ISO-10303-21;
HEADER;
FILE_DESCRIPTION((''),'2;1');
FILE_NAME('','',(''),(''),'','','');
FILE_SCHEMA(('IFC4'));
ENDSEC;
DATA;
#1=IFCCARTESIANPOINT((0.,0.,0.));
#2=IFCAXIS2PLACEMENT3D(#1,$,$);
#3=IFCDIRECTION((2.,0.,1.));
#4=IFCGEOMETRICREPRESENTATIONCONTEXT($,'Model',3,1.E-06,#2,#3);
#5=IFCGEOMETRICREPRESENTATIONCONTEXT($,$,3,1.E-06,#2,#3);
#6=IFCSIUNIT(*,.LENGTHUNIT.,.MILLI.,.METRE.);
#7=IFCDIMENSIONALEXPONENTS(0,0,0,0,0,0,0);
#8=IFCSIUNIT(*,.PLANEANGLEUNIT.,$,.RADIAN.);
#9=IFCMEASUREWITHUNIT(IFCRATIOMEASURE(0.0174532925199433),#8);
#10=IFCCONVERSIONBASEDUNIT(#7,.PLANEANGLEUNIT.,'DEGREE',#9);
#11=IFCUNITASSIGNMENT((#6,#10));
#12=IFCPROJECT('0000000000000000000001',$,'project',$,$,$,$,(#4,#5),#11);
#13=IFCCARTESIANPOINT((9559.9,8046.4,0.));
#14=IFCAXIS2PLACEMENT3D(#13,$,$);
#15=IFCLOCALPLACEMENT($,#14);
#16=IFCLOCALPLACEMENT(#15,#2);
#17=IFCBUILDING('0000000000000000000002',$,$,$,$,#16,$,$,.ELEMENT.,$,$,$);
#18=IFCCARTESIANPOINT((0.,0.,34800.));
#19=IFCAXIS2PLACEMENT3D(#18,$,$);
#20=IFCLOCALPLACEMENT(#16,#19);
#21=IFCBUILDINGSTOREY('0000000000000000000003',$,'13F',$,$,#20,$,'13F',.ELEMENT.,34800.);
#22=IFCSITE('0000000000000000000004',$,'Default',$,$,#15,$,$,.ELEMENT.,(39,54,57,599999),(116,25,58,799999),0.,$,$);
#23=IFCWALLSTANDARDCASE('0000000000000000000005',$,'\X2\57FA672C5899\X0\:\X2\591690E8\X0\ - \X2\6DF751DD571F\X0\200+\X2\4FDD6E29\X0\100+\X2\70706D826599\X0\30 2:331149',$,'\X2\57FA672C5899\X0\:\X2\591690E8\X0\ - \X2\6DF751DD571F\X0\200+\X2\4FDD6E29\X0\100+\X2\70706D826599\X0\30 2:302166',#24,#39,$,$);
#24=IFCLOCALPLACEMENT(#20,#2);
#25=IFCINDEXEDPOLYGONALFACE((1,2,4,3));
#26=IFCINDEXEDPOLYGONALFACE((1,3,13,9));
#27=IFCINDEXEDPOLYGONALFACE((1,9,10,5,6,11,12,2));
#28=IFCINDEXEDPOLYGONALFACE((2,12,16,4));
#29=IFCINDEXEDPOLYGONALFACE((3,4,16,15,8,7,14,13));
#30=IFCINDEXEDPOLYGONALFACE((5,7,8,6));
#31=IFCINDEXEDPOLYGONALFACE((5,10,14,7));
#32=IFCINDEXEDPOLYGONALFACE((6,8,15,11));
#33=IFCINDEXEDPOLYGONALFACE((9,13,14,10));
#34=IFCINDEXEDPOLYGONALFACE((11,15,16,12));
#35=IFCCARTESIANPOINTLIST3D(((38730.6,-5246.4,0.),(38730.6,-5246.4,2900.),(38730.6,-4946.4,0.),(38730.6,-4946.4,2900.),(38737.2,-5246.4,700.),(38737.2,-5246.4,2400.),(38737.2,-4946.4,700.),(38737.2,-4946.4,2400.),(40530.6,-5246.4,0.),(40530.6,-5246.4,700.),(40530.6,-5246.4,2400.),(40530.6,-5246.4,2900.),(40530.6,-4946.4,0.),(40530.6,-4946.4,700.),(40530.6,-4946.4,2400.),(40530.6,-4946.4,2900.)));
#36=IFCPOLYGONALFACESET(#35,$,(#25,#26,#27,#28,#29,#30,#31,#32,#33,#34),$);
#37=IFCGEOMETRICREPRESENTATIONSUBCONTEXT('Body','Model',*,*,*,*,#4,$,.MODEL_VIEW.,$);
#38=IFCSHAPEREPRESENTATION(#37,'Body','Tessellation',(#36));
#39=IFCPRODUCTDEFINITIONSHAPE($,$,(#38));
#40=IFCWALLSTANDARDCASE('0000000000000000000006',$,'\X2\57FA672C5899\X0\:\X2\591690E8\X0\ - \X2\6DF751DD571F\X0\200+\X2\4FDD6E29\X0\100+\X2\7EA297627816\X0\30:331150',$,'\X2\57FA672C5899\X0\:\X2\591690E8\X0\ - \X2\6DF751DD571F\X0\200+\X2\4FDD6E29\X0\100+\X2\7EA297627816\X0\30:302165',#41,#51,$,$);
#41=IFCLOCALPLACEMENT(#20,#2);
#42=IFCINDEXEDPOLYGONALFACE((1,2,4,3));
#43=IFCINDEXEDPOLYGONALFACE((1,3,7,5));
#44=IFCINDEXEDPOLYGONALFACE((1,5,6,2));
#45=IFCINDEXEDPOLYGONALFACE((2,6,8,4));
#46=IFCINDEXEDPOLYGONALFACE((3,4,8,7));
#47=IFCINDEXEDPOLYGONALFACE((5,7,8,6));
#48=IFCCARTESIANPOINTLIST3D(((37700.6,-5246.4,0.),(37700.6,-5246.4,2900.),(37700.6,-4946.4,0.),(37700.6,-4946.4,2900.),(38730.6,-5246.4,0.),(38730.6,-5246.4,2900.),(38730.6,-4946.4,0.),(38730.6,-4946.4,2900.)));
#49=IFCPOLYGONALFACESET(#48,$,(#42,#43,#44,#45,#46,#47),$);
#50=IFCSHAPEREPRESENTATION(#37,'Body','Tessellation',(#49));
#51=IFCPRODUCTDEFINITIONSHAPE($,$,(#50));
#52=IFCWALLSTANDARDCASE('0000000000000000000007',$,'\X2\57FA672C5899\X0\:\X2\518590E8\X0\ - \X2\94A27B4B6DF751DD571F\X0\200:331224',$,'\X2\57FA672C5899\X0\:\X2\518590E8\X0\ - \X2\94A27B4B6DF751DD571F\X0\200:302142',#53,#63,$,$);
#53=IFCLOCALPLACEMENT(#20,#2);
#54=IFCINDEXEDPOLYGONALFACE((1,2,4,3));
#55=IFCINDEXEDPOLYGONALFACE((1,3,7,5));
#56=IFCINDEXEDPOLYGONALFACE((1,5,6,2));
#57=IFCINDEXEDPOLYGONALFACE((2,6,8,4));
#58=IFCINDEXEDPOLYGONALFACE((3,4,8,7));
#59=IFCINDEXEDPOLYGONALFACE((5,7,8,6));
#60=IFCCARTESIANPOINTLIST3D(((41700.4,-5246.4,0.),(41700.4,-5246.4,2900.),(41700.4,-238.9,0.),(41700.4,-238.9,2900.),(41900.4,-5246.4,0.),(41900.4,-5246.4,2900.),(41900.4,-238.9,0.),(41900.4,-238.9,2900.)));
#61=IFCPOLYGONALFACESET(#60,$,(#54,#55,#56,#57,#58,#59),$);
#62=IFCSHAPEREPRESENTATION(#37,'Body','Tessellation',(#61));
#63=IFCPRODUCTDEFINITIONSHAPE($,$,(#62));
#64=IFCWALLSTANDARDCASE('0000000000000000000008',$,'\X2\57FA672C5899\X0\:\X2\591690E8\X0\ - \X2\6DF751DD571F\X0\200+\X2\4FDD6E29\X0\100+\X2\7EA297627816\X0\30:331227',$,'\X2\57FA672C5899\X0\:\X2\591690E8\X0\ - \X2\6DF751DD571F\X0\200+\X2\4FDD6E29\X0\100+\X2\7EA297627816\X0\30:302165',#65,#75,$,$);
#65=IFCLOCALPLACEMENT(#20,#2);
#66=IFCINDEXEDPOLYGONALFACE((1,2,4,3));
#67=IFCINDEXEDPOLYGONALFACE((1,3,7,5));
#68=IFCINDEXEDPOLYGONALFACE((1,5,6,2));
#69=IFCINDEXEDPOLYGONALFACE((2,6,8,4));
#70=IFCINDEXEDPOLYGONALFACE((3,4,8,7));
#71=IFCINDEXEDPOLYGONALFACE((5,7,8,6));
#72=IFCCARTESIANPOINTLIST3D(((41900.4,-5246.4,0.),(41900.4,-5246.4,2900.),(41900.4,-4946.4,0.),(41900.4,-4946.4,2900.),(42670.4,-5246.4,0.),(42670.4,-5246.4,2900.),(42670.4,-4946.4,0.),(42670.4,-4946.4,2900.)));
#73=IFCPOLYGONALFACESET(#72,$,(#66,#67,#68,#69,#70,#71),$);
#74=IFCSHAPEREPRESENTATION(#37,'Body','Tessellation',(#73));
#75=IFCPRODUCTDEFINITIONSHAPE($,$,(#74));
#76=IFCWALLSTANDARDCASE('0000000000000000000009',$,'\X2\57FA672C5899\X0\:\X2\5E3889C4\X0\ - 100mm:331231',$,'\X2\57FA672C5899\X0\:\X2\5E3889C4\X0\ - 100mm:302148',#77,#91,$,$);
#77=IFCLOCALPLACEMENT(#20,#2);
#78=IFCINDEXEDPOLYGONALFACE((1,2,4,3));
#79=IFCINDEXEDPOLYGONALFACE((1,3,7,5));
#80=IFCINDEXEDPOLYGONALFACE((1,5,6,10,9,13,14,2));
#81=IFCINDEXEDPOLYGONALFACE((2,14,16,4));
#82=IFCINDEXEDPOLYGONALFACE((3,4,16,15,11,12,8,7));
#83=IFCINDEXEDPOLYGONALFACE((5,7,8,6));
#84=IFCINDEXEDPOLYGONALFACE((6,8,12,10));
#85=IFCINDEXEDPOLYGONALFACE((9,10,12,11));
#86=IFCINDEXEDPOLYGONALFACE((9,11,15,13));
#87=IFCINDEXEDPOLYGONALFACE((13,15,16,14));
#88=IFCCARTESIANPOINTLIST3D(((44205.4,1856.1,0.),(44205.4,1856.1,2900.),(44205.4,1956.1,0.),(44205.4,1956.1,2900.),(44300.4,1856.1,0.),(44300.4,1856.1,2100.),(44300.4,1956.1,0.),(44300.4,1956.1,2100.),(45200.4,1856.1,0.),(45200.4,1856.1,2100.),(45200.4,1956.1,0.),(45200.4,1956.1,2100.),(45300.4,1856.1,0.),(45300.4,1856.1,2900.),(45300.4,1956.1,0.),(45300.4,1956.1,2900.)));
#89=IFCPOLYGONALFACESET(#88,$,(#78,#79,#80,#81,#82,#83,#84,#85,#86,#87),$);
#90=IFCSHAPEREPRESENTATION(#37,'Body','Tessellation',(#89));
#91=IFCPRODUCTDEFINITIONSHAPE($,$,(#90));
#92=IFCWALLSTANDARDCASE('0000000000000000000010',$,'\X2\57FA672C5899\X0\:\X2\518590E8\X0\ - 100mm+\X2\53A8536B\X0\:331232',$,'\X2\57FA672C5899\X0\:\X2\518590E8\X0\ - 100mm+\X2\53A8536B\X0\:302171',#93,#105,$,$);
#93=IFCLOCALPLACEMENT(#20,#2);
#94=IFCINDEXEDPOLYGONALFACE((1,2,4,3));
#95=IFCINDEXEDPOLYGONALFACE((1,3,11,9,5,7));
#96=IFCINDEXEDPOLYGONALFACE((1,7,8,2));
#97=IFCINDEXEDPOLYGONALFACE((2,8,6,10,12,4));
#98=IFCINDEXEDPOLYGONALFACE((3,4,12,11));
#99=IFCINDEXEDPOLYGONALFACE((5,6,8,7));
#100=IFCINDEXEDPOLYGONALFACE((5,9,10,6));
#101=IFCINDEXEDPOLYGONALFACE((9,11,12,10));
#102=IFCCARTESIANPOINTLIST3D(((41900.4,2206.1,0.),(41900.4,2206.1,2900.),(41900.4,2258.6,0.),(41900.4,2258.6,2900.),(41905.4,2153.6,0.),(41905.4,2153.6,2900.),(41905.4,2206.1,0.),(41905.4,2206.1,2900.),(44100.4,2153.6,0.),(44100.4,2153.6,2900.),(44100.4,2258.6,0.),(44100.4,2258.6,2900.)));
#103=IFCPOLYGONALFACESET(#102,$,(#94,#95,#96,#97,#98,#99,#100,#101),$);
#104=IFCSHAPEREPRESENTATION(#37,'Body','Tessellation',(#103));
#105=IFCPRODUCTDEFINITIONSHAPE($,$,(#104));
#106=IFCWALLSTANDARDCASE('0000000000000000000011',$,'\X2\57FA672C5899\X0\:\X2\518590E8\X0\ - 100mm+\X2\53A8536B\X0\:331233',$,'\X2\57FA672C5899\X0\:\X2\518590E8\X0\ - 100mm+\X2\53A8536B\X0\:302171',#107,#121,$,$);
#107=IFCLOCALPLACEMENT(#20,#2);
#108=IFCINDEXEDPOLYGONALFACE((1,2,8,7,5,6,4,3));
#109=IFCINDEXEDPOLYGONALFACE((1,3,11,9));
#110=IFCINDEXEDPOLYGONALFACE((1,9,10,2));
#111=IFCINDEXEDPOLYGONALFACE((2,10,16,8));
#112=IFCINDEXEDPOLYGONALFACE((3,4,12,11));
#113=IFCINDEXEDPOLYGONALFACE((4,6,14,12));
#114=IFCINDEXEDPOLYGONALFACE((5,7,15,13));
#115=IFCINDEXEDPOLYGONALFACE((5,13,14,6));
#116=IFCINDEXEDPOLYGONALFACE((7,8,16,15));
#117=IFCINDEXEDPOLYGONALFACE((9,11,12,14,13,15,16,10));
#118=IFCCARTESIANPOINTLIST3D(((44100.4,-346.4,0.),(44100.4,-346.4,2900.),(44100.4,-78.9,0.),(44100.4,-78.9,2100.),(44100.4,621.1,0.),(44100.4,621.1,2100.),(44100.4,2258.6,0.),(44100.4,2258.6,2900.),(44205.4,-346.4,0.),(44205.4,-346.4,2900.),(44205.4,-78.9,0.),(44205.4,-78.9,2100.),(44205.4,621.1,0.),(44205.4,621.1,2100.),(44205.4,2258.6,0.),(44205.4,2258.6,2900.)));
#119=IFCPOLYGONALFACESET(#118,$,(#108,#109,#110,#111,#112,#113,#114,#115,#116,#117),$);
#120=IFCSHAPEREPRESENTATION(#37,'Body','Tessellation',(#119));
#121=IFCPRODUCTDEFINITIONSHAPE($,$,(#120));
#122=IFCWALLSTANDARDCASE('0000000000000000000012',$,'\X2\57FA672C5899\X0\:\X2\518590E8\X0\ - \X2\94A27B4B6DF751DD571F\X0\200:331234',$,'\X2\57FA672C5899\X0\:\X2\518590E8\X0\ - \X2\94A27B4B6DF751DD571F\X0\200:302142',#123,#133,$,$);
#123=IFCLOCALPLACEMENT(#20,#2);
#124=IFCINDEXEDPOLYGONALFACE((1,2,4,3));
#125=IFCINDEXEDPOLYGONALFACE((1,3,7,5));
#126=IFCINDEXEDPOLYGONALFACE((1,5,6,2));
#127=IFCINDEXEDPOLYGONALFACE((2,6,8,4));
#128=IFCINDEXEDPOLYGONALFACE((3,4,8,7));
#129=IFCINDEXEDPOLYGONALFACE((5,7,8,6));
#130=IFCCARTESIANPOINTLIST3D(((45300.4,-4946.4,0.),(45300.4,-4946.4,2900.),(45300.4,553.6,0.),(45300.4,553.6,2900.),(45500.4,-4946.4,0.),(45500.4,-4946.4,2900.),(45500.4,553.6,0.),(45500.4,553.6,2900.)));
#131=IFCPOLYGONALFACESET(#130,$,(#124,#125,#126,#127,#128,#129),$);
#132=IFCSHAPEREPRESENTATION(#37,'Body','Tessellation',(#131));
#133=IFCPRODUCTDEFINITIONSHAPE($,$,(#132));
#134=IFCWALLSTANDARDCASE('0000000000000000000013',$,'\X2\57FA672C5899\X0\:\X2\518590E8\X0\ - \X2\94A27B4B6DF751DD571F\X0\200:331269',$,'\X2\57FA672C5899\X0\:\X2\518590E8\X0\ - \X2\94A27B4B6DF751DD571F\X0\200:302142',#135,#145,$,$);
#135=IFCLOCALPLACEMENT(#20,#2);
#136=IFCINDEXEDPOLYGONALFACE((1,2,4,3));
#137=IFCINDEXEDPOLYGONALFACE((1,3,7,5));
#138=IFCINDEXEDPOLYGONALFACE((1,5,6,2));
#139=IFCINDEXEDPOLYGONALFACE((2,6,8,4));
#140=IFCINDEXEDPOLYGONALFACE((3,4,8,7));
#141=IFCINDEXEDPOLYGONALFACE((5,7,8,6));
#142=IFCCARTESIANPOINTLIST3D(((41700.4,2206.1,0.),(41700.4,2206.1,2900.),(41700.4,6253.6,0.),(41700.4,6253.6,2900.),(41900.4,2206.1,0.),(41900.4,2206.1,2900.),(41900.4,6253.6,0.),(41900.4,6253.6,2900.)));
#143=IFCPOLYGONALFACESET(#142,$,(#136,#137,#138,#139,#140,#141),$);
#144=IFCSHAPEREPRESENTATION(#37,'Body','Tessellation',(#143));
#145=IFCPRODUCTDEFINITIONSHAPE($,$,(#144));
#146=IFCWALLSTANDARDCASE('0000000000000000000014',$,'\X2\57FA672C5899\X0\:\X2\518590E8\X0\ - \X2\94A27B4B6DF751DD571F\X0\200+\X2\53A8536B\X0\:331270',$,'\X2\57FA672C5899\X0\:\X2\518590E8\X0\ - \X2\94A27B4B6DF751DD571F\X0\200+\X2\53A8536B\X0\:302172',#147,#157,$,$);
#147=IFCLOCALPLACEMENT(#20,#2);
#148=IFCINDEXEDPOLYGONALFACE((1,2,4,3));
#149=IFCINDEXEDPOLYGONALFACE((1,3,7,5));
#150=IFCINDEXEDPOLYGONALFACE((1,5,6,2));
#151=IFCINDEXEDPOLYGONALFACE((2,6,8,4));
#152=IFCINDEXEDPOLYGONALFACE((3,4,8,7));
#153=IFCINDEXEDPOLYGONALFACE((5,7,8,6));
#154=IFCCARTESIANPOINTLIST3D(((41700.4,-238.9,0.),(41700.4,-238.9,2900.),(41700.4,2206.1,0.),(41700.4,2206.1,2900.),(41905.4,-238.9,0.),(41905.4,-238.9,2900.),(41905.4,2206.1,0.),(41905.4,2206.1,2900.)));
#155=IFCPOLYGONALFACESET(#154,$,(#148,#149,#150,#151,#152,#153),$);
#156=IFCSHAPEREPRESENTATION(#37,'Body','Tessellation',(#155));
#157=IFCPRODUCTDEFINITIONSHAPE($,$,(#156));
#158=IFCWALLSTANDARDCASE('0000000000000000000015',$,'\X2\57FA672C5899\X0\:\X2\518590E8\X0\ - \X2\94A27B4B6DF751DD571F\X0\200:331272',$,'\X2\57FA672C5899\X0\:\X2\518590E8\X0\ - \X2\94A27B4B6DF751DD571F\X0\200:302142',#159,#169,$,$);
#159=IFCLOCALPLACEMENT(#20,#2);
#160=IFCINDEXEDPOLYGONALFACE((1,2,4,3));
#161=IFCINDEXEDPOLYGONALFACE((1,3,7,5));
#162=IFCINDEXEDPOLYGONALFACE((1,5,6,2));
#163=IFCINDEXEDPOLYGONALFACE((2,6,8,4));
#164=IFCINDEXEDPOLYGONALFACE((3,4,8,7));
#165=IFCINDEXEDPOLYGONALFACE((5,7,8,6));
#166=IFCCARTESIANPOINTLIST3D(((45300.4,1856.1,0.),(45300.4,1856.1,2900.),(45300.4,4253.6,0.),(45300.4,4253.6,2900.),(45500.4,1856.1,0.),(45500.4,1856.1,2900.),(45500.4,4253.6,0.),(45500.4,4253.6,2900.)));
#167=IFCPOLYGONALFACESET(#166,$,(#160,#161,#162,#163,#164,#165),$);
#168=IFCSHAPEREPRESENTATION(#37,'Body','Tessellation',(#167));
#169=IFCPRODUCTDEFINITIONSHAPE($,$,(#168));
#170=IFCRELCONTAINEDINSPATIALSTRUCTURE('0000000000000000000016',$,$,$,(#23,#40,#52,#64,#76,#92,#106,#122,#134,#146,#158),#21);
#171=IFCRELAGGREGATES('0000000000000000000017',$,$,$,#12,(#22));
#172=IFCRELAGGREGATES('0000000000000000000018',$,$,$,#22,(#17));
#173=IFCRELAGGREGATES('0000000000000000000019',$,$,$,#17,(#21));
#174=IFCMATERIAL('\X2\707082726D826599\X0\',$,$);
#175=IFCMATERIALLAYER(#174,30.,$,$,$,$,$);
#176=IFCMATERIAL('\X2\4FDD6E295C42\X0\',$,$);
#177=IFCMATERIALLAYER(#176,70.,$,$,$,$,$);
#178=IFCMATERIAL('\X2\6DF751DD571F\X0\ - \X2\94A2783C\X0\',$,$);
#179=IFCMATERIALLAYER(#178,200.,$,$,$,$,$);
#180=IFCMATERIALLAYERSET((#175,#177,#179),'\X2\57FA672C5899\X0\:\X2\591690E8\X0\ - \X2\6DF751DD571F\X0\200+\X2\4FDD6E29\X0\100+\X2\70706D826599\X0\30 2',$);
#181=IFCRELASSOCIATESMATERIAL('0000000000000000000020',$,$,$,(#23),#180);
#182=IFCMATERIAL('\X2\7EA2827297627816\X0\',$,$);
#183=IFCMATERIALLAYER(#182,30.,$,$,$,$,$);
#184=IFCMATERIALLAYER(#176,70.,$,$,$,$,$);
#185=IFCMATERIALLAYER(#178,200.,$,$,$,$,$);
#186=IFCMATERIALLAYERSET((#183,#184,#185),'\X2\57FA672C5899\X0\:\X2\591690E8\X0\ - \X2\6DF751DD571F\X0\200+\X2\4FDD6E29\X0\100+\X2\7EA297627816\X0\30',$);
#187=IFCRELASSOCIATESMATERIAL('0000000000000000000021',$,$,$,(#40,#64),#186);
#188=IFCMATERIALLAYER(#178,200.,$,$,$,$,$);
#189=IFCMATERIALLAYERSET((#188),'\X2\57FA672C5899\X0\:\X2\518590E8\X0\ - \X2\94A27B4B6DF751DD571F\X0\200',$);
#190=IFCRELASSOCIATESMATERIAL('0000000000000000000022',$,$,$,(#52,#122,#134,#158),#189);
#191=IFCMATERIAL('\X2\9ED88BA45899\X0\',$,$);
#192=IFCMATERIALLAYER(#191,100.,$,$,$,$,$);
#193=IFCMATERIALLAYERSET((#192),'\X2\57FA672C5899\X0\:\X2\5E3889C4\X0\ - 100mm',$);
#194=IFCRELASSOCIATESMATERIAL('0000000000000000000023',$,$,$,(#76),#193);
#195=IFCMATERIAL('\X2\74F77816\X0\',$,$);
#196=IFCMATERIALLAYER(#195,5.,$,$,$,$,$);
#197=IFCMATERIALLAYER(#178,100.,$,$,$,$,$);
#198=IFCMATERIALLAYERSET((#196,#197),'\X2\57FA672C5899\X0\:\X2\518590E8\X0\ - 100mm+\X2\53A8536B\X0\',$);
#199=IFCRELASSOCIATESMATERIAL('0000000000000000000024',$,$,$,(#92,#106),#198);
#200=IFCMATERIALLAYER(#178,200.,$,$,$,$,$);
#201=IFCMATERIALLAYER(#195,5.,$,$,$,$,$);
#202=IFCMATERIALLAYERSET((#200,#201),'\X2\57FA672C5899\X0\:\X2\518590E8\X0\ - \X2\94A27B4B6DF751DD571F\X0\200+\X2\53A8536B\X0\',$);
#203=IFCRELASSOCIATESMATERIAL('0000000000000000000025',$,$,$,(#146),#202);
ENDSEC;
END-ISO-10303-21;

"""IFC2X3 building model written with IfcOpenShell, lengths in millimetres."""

from ifc_helpers import new_model, entity, si_unit, converted_unit, direction, frame, frame_2d, origin, place, context, subcontext, project, spatial, polyline, rectangle, outline, extrude, material, layer, layer_set, layer_usage, element, save


model = new_model("IFC2X3")

# Units and contexts
model_context = context("Model", 3, precision=1e-06, world=origin(), true_north=direction((2.0, 0.0, 1.0)))
context_of_model = context(None, 3, precision=1e-06, world=origin(), true_north=direction((2.0, 0.0, 1.0)))
body_context = subcontext(model_context, "Body", "Model", "MODEL_VIEW")
ifc_project = project(units=[si_unit("LENGTHUNIT", "METRE", prefix="MILLI"), converted_unit("PLANEANGLEUNIT", "DEGREE", entity("IfcRatioMeasure", 0.0174532925199433), si_unit("PLANEANGLEUNIT", "RADIAN"), dimensions=[0, 0, 0, 0, 0, 0, 0])], contexts=[model_context, context_of_model])

# Site, building, storey
site_placement = place(None, frame((9559.9, 8046.4, 0.0)))
site = spatial("IfcSite", under=ifc_project, at=site_placement, Name="Default", CompositionType="ELEMENT", RefLatitude=(39, 54, 57, 599999), RefLongitude=(116, 25, 58, 799999), RefElevation=0.0)
building_placement = place(site_placement, origin())
building = spatial("IfcBuilding", under=site, at=building_placement, CompositionType="ELEMENT")
storey_placement = place(building_placement, frame((0.0, 0.0, 34800.0)))
storey = spatial("IfcBuildingStorey", under=building, at=storey_placement, Name="13F", LongName="13F", CompositionType="ELEMENT", Elevation=34800.0)

# Shared definitions
ifc_material_1 = material(Name="混凝土 - 钢砼")
ifc_layer_1 = layer(ifc_material_1, 200.0)
ifc_layer_set_1 = layer_set([ifc_layer_1], Name="基本墙:内部 - 钢筋混凝土200")
ifc_material_2 = material(Name="红色面砖")
ifc_layer_2 = layer(ifc_material_2, 30.0)
ifc_material_3 = material(Name="保温层")
ifc_layer_3 = layer(ifc_material_3, 70.0)
ifc_layer_4 = layer(ifc_material_1, 200.0)
ifc_layer_set_2 = layer_set([ifc_layer_2, ifc_layer_3, ifc_layer_4], Name="基本墙:外部 - 混凝土200+保温100+红面砖30")

# Shared definitions
ifc_material_4 = material(Name="默认墙")
ifc_layer_5 = layer(ifc_material_4, 100.0)
ifc_layer_set_3 = layer_set([ifc_layer_5], Name="基本墙:常规 - 100mm")

# Shared definitions
ifc_material_5 = material(Name="瓷砖")
ifc_layer_6 = layer(ifc_material_5, 5.0)
ifc_layer_7 = layer(ifc_material_1, 100.0)
ifc_layer_set_4 = layer_set([ifc_layer_6, ifc_layer_7], Name="基本墙:内部 - 100mm+厨卫")

# Shared definitions
ifc_layer_8 = layer(ifc_material_1, 200.0)
ifc_layer_9 = layer(ifc_material_5, 5.0)
ifc_layer_set_5 = layer_set([ifc_layer_8, ifc_layer_9], Name="基本墙:内部 - 钢筋混凝土200+厨卫")

# Wall, opening
ifc_material_6 = material(Name="灰色涂料")
ifc_layer_10 = layer(ifc_material_6, 30.0)
ifc_layer_11 = layer(ifc_material_3, 70.0)
ifc_layer_12 = layer(ifc_material_1, 200.0)
ifc_layer_set_6 = layer_set([ifc_layer_10, ifc_layer_11, ifc_layer_12], Name="基本墙:外部 - 混凝土200+保温100+灰涂料30 2")
ifc_layer_usage_1 = layer_usage(ifc_layer_set_6, "AXIS2", "NEGATIVE", 150.0)
wall_1_placement = place(storey_placement, frame((40530.6, -5096.4, 0.0), z_axis=(0.0, 0.0, 1.0), x_axis=(-1.0, 0.0, 0.0)))
wall_1 = element("IfcWallStandardCase", 1, at=wall_1_placement, inside=storey, material=ifc_layer_usage_1, Name="基本墙:外部 - 混凝土200+保温100+灰涂料30 2:331149", ObjectType="基本墙:外部 - 混凝土200+保温100+灰涂料30 2:302166", context=body_context, shape_type="SweptSolid", body=[
    extrude(rectangle(XDim=1800.0, YDim=300.0, at=frame_2d((900.0, 0.0), x_axis=(-1.0, 0.0))), origin(), (0.0, 0.0, 1.0), 2900.0),
])
opening_1_placement = place(wall_1_placement, frame((-6.6, -150.0, 700.0)))
element("IfcOpeningElement", 2, at=opening_1_placement, cuts=wall_1, ObjectType="Opening", context=body_context, shape_type="SweptSolid", body=[
    extrude(rectangle(XDim=1700.0, YDim=1800.0, at=frame_2d((850.0, 900.0), x_axis=(1.0, 0.0))), frame((0.0, 0.0, 0.0), z_axis=(0.0, 1.0, 0.0), x_axis=(0.0, 0.0, 1.0)), (0.0, 0.0, 1.0), 300.0),
])

# Walls
ifc_layer_usage_2 = layer_usage(ifc_layer_set_2, "AXIS2", "NEGATIVE", 150.0)
wall_2_placement = place(storey_placement, frame((38730.6, -5096.4, 0.0), z_axis=(0.0, 0.0, 1.0), x_axis=(-1.0, 0.0, 0.0)))
element("IfcWallStandardCase", 3, at=wall_2_placement, inside=storey, material=ifc_layer_usage_2, Name="基本墙:外部 - 混凝土200+保温100+红面砖30:331150", ObjectType="基本墙:外部 - 混凝土200+保温100+红面砖30:302165", context=body_context, shape_type="SweptSolid", body=[
    extrude(rectangle(XDim=1030.0, YDim=300.0, at=frame_2d((515.0, 0.0), x_axis=(-1.0, 0.0))), origin(), (0.0, 0.0, 1.0), 2900.0),
])
ifc_layer_usage_3 = layer_usage(ifc_layer_set_1, "AXIS2", "NEGATIVE", 100.0)
wall_3_placement = place(storey_placement, frame((41800.4, -5246.4, 0.0), z_axis=(0.0, 0.0, 1.0), x_axis=(0.0, 1.0, 0.0)))
element("IfcWallStandardCase", 4, at=wall_3_placement, inside=storey, material=ifc_layer_usage_3, Name="基本墙:内部 - 钢筋混凝土200:331224", ObjectType="基本墙:内部 - 钢筋混凝土200:302142", context=body_context, shape_type="SweptSolid", body=[
    extrude(rectangle(XDim=5007.5, YDim=200.0, at=frame_2d((2503.8, 0.0), x_axis=(-1.0, 0.0))), origin(), (0.0, 0.0, 1.0), 2900.0),
])
ifc_layer_usage_4 = layer_usage(ifc_layer_set_2, "AXIS2", "POSITIVE", -150.0)
wall_4_placement = place(storey_placement, frame((41900.4, -5096.4, 0.0)))
element("IfcWallStandardCase", 5, at=wall_4_placement, inside=storey, material=ifc_layer_usage_4, Name="基本墙:外部 - 混凝土200+保温100+红面砖30:331227", ObjectType="基本墙:外部 - 混凝土200+保温100+红面砖30:302165", context=body_context, shape_type="SweptSolid", body=[
    extrude(rectangle(XDim=770.0, YDim=300.0, at=frame_2d((385.0, 0.0), x_axis=(-1.0, 0.0))), origin(), (0.0, 0.0, 1.0), 2900.0),
])

# Wall, opening
ifc_layer_usage_5 = layer_usage(ifc_layer_set_3, "AXIS2", "NEGATIVE", 50.0)
wall_5_placement = place(storey_placement, frame((44205.4, 1906.1, 0.0)))
wall_5 = element("IfcWallStandardCase", 6, at=wall_5_placement, inside=storey, material=ifc_layer_usage_5, Name="基本墙:常规 - 100mm:331231", ObjectType="基本墙:常规 - 100mm:302148", context=body_context, shape_type="SweptSolid", body=[
    extrude(rectangle(XDim=1095.0, YDim=100.0, at=frame_2d((547.5, 0.0), x_axis=(-1.0, 0.0))), origin(), (0.0, 0.0, 1.0), 2900.0),
])
opening_2_placement = place(wall_5_placement, frame((95.0, -50.0, 0.0)))
element("IfcOpeningElement", 7, at=opening_2_placement, cuts=wall_5, ObjectType="Opening", context=body_context, shape_type="SweptSolid", body=[
    extrude(rectangle(XDim=2100.0, YDim=900.0, at=frame_2d((1050.0, 450.0), x_axis=(1.0, 0.0))), frame((0.0, 0.0, 0.0), z_axis=(0.0, 1.0, 0.0), x_axis=(0.0, 0.0, 1.0)), (0.0, 0.0, 1.0), 100.0),
])

# Wall
ifc_layer_usage_6 = layer_usage(ifc_layer_set_4, "AXIS2", "POSITIVE", -52.5)
wall_6_placement = place(storey_placement, frame((41900.4, 2206.1, 0.0)))
element("IfcWallStandardCase", 8, at=wall_6_placement, inside=storey, material=ifc_layer_usage_6, Name="基本墙:内部 - 100mm+厨卫:331232", ObjectType="基本墙:内部 - 100mm+厨卫:302171", context=body_context, shape_type="SweptSolid", body=[
    extrude(outline(polyline([(2200.0, -52.5), (2200.0, 52.5), (0.0, 52.5), (0.0, 0.0), (5.0, 0.0), (5.0, -52.5), (2200.0, -52.5)])), origin(), (0.0, 0.0, 1.0), 2900.0),
])

# Wall, opening
ifc_layer_usage_7 = layer_usage(ifc_layer_set_4, "AXIS2", "POSITIVE", -52.5)
wall_7_placement = place(storey_placement, frame((44152.9, 2258.6, 0.0), z_axis=(0.0, 0.0, 1.0), x_axis=(0.0, -1.0, 0.0)))
wall_7 = element("IfcWallStandardCase", 9, at=wall_7_placement, inside=storey, material=ifc_layer_usage_7, Name="基本墙:内部 - 100mm+厨卫:331233", ObjectType="基本墙:内部 - 100mm+厨卫:302171", context=body_context, shape_type="SweptSolid", body=[
    extrude(rectangle(XDim=2605.0, YDim=105.0, at=frame_2d((1302.5, 0.0), x_axis=(-1.0, 0.0))), origin(), (0.0, 0.0, 1.0), 2900.0),
])
opening_3_placement = place(wall_7_placement, frame((2337.5, 52.5, 0.0)))
element("IfcOpeningElement", 10, at=opening_3_placement, cuts=wall_7, ObjectType="Opening", context=body_context, shape_type="SweptSolid", body=[
    extrude(rectangle(XDim=2100.0, YDim=700.0, at=frame_2d((1050.0, 350.0), x_axis=(1.0, 0.0))), frame((0.0, 0.0, 0.0), z_axis=(0.0, -1.0, 0.0), x_axis=(0.0, 0.0, 1.0)), (0.0, 0.0, 1.0), 105.0),
])

# Walls
ifc_layer_usage_8 = layer_usage(ifc_layer_set_1, "AXIS2", "POSITIVE", -100.0)
wall_8_placement = place(storey_placement, frame((45400.4, 553.6, 0.0), z_axis=(0.0, 0.0, 1.0), x_axis=(0.0, -1.0, 0.0)))
element("IfcWallStandardCase", 11, at=wall_8_placement, inside=storey, material=ifc_layer_usage_8, Name="基本墙:内部 - 钢筋混凝土200:331234", ObjectType="基本墙:内部 - 钢筋混凝土200:302142", context=body_context, shape_type="SweptSolid", body=[
    extrude(rectangle(XDim=5500.0, YDim=200.0, at=frame_2d((2750.0, 0.0), x_axis=(-1.0, 0.0))), origin(), (0.0, 0.0, 1.0), 2900.0),
])
ifc_layer_usage_9 = layer_usage(ifc_layer_set_1, "AXIS2", "NEGATIVE", 100.0)
wall_9_placement = place(storey_placement, frame((41800.4, 2206.1, 0.0), z_axis=(0.0, 0.0, 1.0), x_axis=(0.0, 1.0, 0.0)))
element("IfcWallStandardCase", 12, at=wall_9_placement, inside=storey, material=ifc_layer_usage_9, Name="基本墙:内部 - 钢筋混凝土200:331269", ObjectType="基本墙:内部 - 钢筋混凝土200:302142", context=body_context, shape_type="SweptSolid", body=[
    extrude(rectangle(XDim=4047.5, YDim=200.0, at=frame_2d((2023.8, 0.0), x_axis=(-1.0, 0.0))), origin(), (0.0, 0.0, 1.0), 2900.0),
])
ifc_layer_usage_10 = layer_usage(ifc_layer_set_5, "AXIS2", "NEGATIVE", 102.5)
wall_10_placement = place(storey_placement, frame((41802.9, -238.9, 0.0), z_axis=(0.0, 0.0, 1.0), x_axis=(0.0, 1.0, 0.0)))
element("IfcWallStandardCase", 13, at=wall_10_placement, inside=storey, material=ifc_layer_usage_10, Name="基本墙:内部 - 钢筋混凝土200+厨卫:331270", ObjectType="基本墙:内部 - 钢筋混凝土200+厨卫:302172", context=body_context, shape_type="SweptSolid", body=[
    extrude(rectangle(XDim=2445.0, YDim=205.0, at=frame_2d((1222.5, 0.0), x_axis=(-1.0, 0.0))), origin(), (0.0, 0.0, 1.0), 2900.0),
])
ifc_layer_usage_11 = layer_usage(ifc_layer_set_1, "AXIS2", "NEGATIVE", 100.0)
wall_11_placement = place(storey_placement, frame((45400.4, 4253.6, 0.0), z_axis=(0.0, 0.0, 1.0), x_axis=(0.0, -1.0, 0.0)))
element("IfcWallStandardCase", 14, at=wall_11_placement, inside=storey, material=ifc_layer_usage_11, Name="基本墙:内部 - 钢筋混凝土200:331272", ObjectType="基本墙:内部 - 钢筋混凝土200:302142", context=body_context, shape_type="SweptSolid", body=[
    extrude(rectangle(XDim=2397.5, YDim=200.0, at=frame_2d((1198.8, 0.0), x_axis=(-1.0, 0.0))), origin(), (0.0, 0.0, 1.0), 2900.0),
])

save(model, "model.ifc")
